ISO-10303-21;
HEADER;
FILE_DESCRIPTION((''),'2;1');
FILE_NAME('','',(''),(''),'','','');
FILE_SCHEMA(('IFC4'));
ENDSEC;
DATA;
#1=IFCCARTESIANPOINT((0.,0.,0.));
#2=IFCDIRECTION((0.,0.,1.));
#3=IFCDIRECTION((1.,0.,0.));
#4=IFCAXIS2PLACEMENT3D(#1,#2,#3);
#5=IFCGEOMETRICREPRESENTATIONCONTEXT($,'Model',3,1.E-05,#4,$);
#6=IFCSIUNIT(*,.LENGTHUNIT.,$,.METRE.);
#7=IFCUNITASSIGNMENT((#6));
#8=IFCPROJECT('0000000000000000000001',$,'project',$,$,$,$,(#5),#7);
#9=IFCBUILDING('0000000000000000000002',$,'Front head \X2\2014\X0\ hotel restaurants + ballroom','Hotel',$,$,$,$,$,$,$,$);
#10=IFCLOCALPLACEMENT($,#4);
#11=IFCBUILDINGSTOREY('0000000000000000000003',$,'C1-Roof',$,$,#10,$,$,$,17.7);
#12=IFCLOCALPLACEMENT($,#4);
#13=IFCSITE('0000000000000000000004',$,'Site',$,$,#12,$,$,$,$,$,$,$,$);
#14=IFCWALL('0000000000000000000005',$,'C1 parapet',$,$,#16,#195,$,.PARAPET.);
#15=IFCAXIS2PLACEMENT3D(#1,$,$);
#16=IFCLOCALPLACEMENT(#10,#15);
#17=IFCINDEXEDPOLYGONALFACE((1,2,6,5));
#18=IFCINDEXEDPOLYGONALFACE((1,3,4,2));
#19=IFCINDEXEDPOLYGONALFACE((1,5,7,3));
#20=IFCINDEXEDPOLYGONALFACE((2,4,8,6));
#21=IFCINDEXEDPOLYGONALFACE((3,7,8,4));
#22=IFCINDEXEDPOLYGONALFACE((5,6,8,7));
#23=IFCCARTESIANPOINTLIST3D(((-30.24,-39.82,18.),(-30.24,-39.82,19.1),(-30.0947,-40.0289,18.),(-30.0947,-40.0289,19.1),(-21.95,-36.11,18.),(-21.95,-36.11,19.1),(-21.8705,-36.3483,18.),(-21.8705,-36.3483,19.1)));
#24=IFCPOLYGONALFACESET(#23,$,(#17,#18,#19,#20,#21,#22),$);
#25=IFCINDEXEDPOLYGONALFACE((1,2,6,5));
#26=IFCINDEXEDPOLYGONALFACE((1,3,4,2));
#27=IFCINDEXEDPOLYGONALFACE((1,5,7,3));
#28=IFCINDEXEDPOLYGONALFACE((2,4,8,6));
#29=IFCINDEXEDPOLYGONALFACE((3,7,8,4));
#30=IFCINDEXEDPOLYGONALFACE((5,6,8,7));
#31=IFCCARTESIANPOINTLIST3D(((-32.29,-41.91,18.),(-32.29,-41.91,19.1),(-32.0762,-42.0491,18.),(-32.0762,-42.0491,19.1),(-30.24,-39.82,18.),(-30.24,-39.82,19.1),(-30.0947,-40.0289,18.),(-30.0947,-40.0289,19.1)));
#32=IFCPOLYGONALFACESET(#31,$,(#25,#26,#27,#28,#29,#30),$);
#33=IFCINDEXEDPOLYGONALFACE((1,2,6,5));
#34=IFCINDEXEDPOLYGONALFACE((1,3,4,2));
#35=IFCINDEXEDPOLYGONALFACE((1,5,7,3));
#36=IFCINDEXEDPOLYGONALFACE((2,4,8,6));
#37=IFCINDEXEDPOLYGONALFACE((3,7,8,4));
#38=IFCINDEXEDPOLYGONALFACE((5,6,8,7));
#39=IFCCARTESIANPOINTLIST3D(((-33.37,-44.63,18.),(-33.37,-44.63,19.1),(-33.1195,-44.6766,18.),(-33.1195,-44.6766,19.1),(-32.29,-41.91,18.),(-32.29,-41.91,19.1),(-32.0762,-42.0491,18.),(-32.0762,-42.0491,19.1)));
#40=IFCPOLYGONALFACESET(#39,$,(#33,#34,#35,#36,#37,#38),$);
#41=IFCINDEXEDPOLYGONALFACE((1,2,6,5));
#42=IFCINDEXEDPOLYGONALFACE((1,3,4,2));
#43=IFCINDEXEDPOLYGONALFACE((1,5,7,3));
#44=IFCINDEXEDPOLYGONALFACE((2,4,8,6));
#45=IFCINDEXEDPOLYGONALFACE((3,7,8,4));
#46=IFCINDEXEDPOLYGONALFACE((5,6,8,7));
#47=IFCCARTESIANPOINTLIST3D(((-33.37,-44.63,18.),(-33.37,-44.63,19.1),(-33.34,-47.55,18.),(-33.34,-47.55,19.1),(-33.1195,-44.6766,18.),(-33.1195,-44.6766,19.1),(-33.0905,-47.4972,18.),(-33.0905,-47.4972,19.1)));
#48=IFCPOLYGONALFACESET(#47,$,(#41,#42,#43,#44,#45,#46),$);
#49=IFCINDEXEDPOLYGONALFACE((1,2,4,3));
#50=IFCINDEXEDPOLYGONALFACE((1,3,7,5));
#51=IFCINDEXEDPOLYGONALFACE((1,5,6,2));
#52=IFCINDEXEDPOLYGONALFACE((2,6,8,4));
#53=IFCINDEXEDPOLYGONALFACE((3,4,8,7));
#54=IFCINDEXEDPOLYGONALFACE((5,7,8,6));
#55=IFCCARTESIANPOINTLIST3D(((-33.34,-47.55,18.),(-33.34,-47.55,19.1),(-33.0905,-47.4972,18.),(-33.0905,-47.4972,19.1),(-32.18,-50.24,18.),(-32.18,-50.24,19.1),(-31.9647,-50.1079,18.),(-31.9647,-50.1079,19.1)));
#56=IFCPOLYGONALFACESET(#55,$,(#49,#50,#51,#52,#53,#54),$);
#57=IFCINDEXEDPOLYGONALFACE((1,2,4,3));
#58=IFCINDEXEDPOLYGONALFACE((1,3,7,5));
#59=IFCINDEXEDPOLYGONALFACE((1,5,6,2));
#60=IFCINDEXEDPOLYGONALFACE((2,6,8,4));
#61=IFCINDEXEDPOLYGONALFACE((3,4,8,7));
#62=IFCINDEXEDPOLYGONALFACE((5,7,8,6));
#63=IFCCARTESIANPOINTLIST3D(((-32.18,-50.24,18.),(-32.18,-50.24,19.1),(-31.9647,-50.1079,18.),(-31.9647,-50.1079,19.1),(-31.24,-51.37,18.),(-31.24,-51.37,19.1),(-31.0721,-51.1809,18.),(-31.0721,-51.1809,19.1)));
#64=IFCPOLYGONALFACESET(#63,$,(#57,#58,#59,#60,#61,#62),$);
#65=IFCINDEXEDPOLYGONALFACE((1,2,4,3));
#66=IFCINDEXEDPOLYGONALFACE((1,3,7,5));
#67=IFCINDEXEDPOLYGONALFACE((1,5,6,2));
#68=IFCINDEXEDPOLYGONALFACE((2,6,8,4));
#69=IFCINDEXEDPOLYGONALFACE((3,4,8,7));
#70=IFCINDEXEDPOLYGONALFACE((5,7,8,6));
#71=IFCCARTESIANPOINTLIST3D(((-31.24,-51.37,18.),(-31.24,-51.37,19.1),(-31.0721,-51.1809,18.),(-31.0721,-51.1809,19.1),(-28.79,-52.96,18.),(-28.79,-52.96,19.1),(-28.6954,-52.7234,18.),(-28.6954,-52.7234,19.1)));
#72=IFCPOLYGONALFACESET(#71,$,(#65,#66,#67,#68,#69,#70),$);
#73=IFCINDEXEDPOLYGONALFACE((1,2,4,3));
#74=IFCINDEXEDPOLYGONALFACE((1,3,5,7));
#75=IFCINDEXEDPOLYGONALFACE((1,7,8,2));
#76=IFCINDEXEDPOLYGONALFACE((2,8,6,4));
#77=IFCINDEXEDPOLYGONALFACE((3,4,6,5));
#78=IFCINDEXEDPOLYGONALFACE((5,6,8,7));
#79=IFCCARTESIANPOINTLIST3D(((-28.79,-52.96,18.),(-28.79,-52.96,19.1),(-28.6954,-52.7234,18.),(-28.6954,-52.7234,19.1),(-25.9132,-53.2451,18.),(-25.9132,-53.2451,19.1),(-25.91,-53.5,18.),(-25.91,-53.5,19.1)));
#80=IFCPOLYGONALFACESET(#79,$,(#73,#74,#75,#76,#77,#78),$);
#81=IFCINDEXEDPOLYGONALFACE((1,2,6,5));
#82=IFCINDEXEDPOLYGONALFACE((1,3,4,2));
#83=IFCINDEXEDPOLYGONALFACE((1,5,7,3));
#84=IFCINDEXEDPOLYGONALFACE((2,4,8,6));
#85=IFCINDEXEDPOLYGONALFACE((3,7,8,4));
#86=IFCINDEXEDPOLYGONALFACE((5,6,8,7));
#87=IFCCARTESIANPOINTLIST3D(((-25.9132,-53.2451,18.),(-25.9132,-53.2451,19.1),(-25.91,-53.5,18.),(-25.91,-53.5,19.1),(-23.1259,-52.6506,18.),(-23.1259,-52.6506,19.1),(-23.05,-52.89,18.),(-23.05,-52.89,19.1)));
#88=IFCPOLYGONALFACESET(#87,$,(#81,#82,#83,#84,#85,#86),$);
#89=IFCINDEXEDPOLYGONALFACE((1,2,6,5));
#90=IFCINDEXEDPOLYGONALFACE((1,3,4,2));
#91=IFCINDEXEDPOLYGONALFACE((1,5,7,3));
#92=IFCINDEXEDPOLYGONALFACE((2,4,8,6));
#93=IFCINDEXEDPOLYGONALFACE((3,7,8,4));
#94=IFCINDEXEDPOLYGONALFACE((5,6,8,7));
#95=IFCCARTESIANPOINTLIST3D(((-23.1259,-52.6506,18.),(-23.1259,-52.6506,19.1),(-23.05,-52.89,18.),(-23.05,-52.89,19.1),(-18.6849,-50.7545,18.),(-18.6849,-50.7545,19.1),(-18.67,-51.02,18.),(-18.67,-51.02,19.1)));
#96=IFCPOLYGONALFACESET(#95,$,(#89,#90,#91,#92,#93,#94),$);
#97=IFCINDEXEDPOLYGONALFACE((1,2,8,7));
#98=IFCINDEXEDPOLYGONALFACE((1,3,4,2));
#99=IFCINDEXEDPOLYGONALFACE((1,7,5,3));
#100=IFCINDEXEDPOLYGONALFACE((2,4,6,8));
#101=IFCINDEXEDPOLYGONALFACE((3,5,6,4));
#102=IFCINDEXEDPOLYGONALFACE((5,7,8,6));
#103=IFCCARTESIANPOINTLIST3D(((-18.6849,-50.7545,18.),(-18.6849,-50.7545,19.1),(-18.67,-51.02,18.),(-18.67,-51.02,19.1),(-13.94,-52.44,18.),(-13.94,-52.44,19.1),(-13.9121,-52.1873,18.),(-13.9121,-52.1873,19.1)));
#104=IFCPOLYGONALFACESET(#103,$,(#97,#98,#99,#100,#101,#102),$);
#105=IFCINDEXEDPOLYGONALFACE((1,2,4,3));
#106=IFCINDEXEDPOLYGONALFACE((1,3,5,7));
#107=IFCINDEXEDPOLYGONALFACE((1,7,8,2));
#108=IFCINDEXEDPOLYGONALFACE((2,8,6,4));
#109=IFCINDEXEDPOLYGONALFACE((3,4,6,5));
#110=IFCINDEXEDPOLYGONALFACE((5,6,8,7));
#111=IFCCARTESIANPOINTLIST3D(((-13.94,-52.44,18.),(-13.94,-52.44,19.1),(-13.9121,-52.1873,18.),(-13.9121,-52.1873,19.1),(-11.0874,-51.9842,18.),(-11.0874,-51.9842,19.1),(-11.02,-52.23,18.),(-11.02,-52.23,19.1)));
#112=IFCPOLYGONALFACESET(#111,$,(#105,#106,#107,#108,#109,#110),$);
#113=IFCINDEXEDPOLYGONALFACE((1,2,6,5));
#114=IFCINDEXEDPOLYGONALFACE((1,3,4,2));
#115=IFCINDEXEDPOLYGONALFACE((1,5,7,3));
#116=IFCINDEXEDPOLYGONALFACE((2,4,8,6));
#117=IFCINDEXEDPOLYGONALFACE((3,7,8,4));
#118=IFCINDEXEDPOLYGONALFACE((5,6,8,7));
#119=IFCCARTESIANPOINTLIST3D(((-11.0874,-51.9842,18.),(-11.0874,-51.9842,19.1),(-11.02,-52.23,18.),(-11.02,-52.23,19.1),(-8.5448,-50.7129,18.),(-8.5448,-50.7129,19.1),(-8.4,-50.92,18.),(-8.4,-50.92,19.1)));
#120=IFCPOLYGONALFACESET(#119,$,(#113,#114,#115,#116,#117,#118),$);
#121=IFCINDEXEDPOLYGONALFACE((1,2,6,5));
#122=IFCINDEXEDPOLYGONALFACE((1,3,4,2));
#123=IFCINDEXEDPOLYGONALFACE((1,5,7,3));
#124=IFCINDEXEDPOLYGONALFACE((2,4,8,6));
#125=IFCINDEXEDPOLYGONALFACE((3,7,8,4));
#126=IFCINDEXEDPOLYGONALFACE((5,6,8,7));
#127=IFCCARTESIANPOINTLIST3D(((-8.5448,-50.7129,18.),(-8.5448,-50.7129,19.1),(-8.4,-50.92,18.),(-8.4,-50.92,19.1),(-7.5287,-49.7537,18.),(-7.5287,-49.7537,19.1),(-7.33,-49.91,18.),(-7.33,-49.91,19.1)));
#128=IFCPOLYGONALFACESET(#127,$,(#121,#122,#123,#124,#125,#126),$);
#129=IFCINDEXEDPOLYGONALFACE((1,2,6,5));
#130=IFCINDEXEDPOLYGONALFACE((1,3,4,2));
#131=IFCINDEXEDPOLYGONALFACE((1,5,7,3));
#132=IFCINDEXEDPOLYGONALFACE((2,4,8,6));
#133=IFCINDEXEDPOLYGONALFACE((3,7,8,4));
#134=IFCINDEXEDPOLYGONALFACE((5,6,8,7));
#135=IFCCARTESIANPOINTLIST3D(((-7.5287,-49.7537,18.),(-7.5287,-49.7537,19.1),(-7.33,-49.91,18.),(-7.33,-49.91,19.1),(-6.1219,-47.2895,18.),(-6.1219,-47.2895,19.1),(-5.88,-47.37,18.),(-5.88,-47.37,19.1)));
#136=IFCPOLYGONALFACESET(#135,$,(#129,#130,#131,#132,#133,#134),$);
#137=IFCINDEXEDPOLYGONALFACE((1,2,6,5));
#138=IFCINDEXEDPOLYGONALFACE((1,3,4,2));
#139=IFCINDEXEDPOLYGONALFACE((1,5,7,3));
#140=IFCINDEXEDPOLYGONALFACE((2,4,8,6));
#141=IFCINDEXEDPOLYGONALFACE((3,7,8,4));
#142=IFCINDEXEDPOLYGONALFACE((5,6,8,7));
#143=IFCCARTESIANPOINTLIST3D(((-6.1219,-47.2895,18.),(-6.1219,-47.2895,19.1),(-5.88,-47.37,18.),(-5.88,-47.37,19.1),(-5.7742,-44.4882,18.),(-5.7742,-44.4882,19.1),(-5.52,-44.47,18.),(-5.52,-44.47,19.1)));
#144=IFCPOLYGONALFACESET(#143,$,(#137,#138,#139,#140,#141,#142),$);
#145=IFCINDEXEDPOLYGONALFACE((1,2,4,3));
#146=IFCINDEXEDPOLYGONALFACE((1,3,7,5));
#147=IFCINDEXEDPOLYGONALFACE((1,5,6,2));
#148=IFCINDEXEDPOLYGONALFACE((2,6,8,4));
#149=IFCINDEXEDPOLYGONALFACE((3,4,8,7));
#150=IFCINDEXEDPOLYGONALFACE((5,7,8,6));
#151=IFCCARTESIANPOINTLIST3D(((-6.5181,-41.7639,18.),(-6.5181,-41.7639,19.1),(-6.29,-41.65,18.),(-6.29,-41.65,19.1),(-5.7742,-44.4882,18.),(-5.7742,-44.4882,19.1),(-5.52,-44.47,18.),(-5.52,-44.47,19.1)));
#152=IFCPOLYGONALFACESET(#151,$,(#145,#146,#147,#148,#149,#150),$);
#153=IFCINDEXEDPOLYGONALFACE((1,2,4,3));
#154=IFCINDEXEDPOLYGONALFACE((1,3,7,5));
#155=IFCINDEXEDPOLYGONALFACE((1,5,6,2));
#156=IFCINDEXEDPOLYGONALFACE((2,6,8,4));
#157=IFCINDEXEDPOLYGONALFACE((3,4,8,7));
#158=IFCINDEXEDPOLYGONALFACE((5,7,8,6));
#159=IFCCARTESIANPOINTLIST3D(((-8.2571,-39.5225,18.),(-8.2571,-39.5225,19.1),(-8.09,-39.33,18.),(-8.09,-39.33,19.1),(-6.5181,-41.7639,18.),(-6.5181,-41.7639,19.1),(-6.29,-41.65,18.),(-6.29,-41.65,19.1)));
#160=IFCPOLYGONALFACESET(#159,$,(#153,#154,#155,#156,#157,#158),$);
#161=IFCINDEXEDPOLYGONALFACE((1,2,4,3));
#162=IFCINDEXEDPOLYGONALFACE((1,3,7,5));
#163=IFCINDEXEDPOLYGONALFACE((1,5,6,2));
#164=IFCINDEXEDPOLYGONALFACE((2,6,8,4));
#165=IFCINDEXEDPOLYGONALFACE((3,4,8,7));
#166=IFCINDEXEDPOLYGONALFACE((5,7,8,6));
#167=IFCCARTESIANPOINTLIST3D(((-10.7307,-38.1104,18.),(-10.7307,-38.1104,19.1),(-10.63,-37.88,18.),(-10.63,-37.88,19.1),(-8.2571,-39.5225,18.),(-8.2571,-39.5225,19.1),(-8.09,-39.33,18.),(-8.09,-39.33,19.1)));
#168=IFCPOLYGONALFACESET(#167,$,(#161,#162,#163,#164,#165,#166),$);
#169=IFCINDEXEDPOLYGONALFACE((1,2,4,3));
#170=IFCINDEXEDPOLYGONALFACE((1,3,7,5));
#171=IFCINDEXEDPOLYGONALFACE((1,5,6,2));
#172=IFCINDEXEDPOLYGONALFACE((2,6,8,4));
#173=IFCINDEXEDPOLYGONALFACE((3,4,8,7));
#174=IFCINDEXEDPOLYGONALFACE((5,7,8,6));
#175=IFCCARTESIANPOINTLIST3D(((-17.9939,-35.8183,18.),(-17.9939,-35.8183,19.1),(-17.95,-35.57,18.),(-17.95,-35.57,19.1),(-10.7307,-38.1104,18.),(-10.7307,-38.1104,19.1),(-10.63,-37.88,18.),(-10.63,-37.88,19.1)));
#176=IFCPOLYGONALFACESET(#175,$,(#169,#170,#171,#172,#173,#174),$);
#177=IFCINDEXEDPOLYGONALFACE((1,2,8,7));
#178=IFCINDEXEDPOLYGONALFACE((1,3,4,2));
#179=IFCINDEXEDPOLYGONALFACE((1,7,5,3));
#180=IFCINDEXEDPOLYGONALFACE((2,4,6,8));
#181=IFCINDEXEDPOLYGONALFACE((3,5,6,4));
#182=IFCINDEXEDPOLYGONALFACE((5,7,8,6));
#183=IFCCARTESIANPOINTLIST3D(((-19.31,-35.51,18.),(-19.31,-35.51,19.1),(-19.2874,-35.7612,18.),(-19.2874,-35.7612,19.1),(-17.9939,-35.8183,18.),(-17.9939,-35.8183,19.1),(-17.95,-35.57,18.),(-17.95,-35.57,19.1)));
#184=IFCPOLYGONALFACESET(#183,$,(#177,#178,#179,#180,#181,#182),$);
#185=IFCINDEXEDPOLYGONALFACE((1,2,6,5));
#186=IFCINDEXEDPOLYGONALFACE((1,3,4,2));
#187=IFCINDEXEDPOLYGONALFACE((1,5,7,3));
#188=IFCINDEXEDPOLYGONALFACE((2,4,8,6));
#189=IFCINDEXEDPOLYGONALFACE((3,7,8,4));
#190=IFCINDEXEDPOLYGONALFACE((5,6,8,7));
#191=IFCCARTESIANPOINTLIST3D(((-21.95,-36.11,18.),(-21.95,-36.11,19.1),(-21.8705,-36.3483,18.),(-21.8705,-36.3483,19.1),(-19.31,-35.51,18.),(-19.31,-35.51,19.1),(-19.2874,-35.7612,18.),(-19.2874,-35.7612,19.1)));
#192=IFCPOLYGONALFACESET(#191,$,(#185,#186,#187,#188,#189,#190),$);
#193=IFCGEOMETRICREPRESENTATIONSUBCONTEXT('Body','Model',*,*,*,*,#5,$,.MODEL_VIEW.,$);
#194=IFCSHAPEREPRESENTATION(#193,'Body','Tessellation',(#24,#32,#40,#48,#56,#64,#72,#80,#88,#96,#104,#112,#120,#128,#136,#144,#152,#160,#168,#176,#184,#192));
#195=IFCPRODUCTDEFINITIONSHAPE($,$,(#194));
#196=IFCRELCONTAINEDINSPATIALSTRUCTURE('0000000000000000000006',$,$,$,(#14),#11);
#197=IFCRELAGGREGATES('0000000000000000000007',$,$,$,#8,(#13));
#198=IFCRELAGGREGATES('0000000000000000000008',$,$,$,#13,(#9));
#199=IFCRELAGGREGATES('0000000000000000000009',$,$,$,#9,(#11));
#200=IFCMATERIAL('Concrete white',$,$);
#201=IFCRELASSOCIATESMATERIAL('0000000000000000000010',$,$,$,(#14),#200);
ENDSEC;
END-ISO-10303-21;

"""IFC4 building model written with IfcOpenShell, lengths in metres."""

from ifc_helpers import new_model, si_unit, frame, origin_with_axes, place, context, subcontext, project, spatial, polyline, outline, extrude, material, element, save


model = new_model("IFC4")

# Units and contexts
model_context = context("Model", 3, precision=1e-05, world=origin_with_axes())
body_context = subcontext(model_context, "Body", "Model", "MODEL_VIEW")
ifc_project = project(units=[si_unit("LENGTHUNIT", "METRE")], contexts=[model_context])

# Site, building, storey
site_placement = place(None, origin_with_axes())
site = spatial("IfcSite", under=ifc_project, at=site_placement, Name="Site")
building = spatial("IfcBuilding", under=site, Name="Front head — hotel restaurants + ballroom", Description="Hotel")
storey_placement = place(None, origin_with_axes())
storey = spatial("IfcBuildingStorey", under=building, at=storey_placement, Name="C1-Roof", Elevation=17.7)

# Wall
ifc_material_1 = material(Name="Concrete white")
wall_placement = place(storey_placement, origin_with_axes())
element("IfcWall", 1, at=wall_placement, inside=storey, material=ifc_material_1, Name="C1 parapet", PredefinedType="PARAPET", context=body_context, shape_type="SweptSolid", body=[
    extrude(outline(polyline([(-21.95, -36.11), (-30.24, -39.82), (-30.0947, -40.0289), (-21.8705, -36.3483), (-21.95, -36.11)])), frame((0.0, 0.0, 18.0), z_axis=(0.0, 0.0, 1.0), x_axis=(1.0, 0.0, 0.0)), (0.0, 0.0, 1.0), 1.1),
    extrude(outline(polyline([(-30.24, -39.82), (-32.29, -41.91), (-32.0762, -42.0491), (-30.0947, -40.0289), (-30.24, -39.82)])), frame((0.0, 0.0, 18.0), z_axis=(0.0, 0.0, 1.0), x_axis=(1.0, 0.0, 0.0)), (0.0, 0.0, 1.0), 1.1),
    extrude(outline(polyline([(-32.29, -41.91), (-33.37, -44.63), (-33.1195, -44.6766), (-32.0762, -42.0491), (-32.29, -41.91)])), frame((0.0, 0.0, 18.0), z_axis=(0.0, 0.0, 1.0), x_axis=(1.0, 0.0, 0.0)), (0.0, 0.0, 1.0), 1.1),
    extrude(outline(polyline([(-33.37, -44.63), (-33.34, -47.55), (-33.0905, -47.4972), (-33.1195, -44.6766), (-33.37, -44.63)])), frame((0.0, 0.0, 18.0), z_axis=(0.0, 0.0, 1.0), x_axis=(1.0, 0.0, 0.0)), (0.0, 0.0, 1.0), 1.1),
    extrude(outline(polyline([(-33.34, -47.55), (-32.18, -50.24), (-31.9647, -50.1079), (-33.0905, -47.4972), (-33.34, -47.55)])), frame((0.0, 0.0, 18.0), z_axis=(0.0, 0.0, 1.0), x_axis=(1.0, 0.0, 0.0)), (0.0, 0.0, 1.0), 1.1),
    extrude(outline(polyline([(-32.18, -50.24), (-31.24, -51.37), (-31.0721, -51.1809), (-31.9647, -50.1079), (-32.18, -50.24)])), frame((0.0, 0.0, 18.0), z_axis=(0.0, 0.0, 1.0), x_axis=(1.0, 0.0, 0.0)), (0.0, 0.0, 1.0), 1.1),
    extrude(outline(polyline([(-31.24, -51.37), (-28.79, -52.96), (-28.6954, -52.7234), (-31.0721, -51.1809), (-31.24, -51.37)])), frame((0.0, 0.0, 18.0), z_axis=(0.0, 0.0, 1.0), x_axis=(1.0, 0.0, 0.0)), (0.0, 0.0, 1.0), 1.1),
    extrude(outline(polyline([(-28.79, -52.96), (-25.91, -53.5), (-25.9132, -53.2451), (-28.6954, -52.7234), (-28.79, -52.96)])), frame((0.0, 0.0, 18.0), z_axis=(0.0, 0.0, 1.0), x_axis=(1.0, 0.0, 0.0)), (0.0, 0.0, 1.0), 1.1),
    extrude(outline(polyline([(-25.91, -53.5), (-23.05, -52.89), (-23.1259, -52.6506), (-25.9132, -53.2451), (-25.91, -53.5)])), frame((0.0, 0.0, 18.0), z_axis=(0.0, 0.0, 1.0), x_axis=(1.0, 0.0, 0.0)), (0.0, 0.0, 1.0), 1.1),
    extrude(outline(polyline([(-23.05, -52.89), (-18.67, -51.02), (-18.6849, -50.7545), (-23.1259, -52.6506), (-23.05, -52.89)])), frame((0.0, 0.0, 18.0), z_axis=(0.0, 0.0, 1.0), x_axis=(1.0, 0.0, 0.0)), (0.0, 0.0, 1.0), 1.1),
    extrude(outline(polyline([(-18.67, -51.02), (-13.94, -52.44), (-13.9121, -52.1873), (-18.6849, -50.7545), (-18.67, -51.02)])), frame((0.0, 0.0, 18.0), z_axis=(0.0, 0.0, 1.0), x_axis=(1.0, 0.0, 0.0)), (0.0, 0.0, 1.0), 1.1),
    extrude(outline(polyline([(-13.94, -52.44), (-11.02, -52.23), (-11.0874, -51.9842), (-13.9121, -52.1873), (-13.94, -52.44)])), frame((0.0, 0.0, 18.0), z_axis=(0.0, 0.0, 1.0), x_axis=(1.0, 0.0, 0.0)), (0.0, 0.0, 1.0), 1.1),
    extrude(outline(polyline([(-11.02, -52.23), (-8.4, -50.92), (-8.5448, -50.7129), (-11.0874, -51.9842), (-11.02, -52.23)])), frame((0.0, 0.0, 18.0), z_axis=(0.0, 0.0, 1.0), x_axis=(1.0, 0.0, 0.0)), (0.0, 0.0, 1.0), 1.1),
    extrude(outline(polyline([(-8.4, -50.92), (-7.33, -49.91), (-7.5287, -49.7537), (-8.5448, -50.7129), (-8.4, -50.92)])), frame((0.0, 0.0, 18.0), z_axis=(0.0, 0.0, 1.0), x_axis=(1.0, 0.0, 0.0)), (0.0, 0.0, 1.0), 1.1),
    extrude(outline(polyline([(-7.33, -49.91), (-5.88, -47.37), (-6.1219, -47.2895), (-7.5287, -49.7537), (-7.33, -49.91)])), frame((0.0, 0.0, 18.0), z_axis=(0.0, 0.0, 1.0), x_axis=(1.0, 0.0, 0.0)), (0.0, 0.0, 1.0), 1.1),
    extrude(outline(polyline([(-5.88, -47.37), (-5.52, -44.47), (-5.7742, -44.4882), (-6.1219, -47.2895), (-5.88, -47.37)])), frame((0.0, 0.0, 18.0), z_axis=(0.0, 0.0, 1.0), x_axis=(1.0, 0.0, 0.0)), (0.0, 0.0, 1.0), 1.1),
    extrude(outline(polyline([(-5.52, -44.47), (-6.29, -41.65), (-6.5181, -41.7639), (-5.7742, -44.4882), (-5.52, -44.47)])), frame((0.0, 0.0, 18.0), z_axis=(0.0, 0.0, 1.0), x_axis=(1.0, 0.0, 0.0)), (0.0, 0.0, 1.0), 1.1),
    extrude(outline(polyline([(-6.29, -41.65), (-8.09, -39.33), (-8.2571, -39.5225), (-6.5181, -41.7639), (-6.29, -41.65)])), frame((0.0, 0.0, 18.0), z_axis=(0.0, 0.0, 1.0), x_axis=(1.0, 0.0, 0.0)), (0.0, 0.0, 1.0), 1.1),
    extrude(outline(polyline([(-8.09, -39.33), (-10.63, -37.88), (-10.7307, -38.1104), (-8.2571, -39.5225), (-8.09, -39.33)])), frame((0.0, 0.0, 18.0), z_axis=(0.0, 0.0, 1.0), x_axis=(1.0, 0.0, 0.0)), (0.0, 0.0, 1.0), 1.1),
    extrude(outline(polyline([(-10.63, -37.88), (-17.95, -35.57), (-17.9939, -35.8183), (-10.7307, -38.1104), (-10.63, -37.88)])), frame((0.0, 0.0, 18.0), z_axis=(0.0, 0.0, 1.0), x_axis=(1.0, 0.0, 0.0)), (0.0, 0.0, 1.0), 1.1),
    extrude(outline(polyline([(-17.95, -35.57), (-19.31, -35.51), (-19.2874, -35.7612), (-17.9939, -35.8183), (-17.95, -35.57)])), frame((0.0, 0.0, 18.0), z_axis=(0.0, 0.0, 1.0), x_axis=(1.0, 0.0, 0.0)), (0.0, 0.0, 1.0), 1.1),
    extrude(outline(polyline([(-19.31, -35.51), (-21.95, -36.11), (-21.8705, -36.3483), (-19.2874, -35.7612), (-19.31, -35.51)])), frame((0.0, 0.0, 18.0), z_axis=(0.0, 0.0, 1.0), x_axis=(1.0, 0.0, 0.0)), (0.0, 0.0, 1.0), 1.1),
])

save(model, "model.ifc")
